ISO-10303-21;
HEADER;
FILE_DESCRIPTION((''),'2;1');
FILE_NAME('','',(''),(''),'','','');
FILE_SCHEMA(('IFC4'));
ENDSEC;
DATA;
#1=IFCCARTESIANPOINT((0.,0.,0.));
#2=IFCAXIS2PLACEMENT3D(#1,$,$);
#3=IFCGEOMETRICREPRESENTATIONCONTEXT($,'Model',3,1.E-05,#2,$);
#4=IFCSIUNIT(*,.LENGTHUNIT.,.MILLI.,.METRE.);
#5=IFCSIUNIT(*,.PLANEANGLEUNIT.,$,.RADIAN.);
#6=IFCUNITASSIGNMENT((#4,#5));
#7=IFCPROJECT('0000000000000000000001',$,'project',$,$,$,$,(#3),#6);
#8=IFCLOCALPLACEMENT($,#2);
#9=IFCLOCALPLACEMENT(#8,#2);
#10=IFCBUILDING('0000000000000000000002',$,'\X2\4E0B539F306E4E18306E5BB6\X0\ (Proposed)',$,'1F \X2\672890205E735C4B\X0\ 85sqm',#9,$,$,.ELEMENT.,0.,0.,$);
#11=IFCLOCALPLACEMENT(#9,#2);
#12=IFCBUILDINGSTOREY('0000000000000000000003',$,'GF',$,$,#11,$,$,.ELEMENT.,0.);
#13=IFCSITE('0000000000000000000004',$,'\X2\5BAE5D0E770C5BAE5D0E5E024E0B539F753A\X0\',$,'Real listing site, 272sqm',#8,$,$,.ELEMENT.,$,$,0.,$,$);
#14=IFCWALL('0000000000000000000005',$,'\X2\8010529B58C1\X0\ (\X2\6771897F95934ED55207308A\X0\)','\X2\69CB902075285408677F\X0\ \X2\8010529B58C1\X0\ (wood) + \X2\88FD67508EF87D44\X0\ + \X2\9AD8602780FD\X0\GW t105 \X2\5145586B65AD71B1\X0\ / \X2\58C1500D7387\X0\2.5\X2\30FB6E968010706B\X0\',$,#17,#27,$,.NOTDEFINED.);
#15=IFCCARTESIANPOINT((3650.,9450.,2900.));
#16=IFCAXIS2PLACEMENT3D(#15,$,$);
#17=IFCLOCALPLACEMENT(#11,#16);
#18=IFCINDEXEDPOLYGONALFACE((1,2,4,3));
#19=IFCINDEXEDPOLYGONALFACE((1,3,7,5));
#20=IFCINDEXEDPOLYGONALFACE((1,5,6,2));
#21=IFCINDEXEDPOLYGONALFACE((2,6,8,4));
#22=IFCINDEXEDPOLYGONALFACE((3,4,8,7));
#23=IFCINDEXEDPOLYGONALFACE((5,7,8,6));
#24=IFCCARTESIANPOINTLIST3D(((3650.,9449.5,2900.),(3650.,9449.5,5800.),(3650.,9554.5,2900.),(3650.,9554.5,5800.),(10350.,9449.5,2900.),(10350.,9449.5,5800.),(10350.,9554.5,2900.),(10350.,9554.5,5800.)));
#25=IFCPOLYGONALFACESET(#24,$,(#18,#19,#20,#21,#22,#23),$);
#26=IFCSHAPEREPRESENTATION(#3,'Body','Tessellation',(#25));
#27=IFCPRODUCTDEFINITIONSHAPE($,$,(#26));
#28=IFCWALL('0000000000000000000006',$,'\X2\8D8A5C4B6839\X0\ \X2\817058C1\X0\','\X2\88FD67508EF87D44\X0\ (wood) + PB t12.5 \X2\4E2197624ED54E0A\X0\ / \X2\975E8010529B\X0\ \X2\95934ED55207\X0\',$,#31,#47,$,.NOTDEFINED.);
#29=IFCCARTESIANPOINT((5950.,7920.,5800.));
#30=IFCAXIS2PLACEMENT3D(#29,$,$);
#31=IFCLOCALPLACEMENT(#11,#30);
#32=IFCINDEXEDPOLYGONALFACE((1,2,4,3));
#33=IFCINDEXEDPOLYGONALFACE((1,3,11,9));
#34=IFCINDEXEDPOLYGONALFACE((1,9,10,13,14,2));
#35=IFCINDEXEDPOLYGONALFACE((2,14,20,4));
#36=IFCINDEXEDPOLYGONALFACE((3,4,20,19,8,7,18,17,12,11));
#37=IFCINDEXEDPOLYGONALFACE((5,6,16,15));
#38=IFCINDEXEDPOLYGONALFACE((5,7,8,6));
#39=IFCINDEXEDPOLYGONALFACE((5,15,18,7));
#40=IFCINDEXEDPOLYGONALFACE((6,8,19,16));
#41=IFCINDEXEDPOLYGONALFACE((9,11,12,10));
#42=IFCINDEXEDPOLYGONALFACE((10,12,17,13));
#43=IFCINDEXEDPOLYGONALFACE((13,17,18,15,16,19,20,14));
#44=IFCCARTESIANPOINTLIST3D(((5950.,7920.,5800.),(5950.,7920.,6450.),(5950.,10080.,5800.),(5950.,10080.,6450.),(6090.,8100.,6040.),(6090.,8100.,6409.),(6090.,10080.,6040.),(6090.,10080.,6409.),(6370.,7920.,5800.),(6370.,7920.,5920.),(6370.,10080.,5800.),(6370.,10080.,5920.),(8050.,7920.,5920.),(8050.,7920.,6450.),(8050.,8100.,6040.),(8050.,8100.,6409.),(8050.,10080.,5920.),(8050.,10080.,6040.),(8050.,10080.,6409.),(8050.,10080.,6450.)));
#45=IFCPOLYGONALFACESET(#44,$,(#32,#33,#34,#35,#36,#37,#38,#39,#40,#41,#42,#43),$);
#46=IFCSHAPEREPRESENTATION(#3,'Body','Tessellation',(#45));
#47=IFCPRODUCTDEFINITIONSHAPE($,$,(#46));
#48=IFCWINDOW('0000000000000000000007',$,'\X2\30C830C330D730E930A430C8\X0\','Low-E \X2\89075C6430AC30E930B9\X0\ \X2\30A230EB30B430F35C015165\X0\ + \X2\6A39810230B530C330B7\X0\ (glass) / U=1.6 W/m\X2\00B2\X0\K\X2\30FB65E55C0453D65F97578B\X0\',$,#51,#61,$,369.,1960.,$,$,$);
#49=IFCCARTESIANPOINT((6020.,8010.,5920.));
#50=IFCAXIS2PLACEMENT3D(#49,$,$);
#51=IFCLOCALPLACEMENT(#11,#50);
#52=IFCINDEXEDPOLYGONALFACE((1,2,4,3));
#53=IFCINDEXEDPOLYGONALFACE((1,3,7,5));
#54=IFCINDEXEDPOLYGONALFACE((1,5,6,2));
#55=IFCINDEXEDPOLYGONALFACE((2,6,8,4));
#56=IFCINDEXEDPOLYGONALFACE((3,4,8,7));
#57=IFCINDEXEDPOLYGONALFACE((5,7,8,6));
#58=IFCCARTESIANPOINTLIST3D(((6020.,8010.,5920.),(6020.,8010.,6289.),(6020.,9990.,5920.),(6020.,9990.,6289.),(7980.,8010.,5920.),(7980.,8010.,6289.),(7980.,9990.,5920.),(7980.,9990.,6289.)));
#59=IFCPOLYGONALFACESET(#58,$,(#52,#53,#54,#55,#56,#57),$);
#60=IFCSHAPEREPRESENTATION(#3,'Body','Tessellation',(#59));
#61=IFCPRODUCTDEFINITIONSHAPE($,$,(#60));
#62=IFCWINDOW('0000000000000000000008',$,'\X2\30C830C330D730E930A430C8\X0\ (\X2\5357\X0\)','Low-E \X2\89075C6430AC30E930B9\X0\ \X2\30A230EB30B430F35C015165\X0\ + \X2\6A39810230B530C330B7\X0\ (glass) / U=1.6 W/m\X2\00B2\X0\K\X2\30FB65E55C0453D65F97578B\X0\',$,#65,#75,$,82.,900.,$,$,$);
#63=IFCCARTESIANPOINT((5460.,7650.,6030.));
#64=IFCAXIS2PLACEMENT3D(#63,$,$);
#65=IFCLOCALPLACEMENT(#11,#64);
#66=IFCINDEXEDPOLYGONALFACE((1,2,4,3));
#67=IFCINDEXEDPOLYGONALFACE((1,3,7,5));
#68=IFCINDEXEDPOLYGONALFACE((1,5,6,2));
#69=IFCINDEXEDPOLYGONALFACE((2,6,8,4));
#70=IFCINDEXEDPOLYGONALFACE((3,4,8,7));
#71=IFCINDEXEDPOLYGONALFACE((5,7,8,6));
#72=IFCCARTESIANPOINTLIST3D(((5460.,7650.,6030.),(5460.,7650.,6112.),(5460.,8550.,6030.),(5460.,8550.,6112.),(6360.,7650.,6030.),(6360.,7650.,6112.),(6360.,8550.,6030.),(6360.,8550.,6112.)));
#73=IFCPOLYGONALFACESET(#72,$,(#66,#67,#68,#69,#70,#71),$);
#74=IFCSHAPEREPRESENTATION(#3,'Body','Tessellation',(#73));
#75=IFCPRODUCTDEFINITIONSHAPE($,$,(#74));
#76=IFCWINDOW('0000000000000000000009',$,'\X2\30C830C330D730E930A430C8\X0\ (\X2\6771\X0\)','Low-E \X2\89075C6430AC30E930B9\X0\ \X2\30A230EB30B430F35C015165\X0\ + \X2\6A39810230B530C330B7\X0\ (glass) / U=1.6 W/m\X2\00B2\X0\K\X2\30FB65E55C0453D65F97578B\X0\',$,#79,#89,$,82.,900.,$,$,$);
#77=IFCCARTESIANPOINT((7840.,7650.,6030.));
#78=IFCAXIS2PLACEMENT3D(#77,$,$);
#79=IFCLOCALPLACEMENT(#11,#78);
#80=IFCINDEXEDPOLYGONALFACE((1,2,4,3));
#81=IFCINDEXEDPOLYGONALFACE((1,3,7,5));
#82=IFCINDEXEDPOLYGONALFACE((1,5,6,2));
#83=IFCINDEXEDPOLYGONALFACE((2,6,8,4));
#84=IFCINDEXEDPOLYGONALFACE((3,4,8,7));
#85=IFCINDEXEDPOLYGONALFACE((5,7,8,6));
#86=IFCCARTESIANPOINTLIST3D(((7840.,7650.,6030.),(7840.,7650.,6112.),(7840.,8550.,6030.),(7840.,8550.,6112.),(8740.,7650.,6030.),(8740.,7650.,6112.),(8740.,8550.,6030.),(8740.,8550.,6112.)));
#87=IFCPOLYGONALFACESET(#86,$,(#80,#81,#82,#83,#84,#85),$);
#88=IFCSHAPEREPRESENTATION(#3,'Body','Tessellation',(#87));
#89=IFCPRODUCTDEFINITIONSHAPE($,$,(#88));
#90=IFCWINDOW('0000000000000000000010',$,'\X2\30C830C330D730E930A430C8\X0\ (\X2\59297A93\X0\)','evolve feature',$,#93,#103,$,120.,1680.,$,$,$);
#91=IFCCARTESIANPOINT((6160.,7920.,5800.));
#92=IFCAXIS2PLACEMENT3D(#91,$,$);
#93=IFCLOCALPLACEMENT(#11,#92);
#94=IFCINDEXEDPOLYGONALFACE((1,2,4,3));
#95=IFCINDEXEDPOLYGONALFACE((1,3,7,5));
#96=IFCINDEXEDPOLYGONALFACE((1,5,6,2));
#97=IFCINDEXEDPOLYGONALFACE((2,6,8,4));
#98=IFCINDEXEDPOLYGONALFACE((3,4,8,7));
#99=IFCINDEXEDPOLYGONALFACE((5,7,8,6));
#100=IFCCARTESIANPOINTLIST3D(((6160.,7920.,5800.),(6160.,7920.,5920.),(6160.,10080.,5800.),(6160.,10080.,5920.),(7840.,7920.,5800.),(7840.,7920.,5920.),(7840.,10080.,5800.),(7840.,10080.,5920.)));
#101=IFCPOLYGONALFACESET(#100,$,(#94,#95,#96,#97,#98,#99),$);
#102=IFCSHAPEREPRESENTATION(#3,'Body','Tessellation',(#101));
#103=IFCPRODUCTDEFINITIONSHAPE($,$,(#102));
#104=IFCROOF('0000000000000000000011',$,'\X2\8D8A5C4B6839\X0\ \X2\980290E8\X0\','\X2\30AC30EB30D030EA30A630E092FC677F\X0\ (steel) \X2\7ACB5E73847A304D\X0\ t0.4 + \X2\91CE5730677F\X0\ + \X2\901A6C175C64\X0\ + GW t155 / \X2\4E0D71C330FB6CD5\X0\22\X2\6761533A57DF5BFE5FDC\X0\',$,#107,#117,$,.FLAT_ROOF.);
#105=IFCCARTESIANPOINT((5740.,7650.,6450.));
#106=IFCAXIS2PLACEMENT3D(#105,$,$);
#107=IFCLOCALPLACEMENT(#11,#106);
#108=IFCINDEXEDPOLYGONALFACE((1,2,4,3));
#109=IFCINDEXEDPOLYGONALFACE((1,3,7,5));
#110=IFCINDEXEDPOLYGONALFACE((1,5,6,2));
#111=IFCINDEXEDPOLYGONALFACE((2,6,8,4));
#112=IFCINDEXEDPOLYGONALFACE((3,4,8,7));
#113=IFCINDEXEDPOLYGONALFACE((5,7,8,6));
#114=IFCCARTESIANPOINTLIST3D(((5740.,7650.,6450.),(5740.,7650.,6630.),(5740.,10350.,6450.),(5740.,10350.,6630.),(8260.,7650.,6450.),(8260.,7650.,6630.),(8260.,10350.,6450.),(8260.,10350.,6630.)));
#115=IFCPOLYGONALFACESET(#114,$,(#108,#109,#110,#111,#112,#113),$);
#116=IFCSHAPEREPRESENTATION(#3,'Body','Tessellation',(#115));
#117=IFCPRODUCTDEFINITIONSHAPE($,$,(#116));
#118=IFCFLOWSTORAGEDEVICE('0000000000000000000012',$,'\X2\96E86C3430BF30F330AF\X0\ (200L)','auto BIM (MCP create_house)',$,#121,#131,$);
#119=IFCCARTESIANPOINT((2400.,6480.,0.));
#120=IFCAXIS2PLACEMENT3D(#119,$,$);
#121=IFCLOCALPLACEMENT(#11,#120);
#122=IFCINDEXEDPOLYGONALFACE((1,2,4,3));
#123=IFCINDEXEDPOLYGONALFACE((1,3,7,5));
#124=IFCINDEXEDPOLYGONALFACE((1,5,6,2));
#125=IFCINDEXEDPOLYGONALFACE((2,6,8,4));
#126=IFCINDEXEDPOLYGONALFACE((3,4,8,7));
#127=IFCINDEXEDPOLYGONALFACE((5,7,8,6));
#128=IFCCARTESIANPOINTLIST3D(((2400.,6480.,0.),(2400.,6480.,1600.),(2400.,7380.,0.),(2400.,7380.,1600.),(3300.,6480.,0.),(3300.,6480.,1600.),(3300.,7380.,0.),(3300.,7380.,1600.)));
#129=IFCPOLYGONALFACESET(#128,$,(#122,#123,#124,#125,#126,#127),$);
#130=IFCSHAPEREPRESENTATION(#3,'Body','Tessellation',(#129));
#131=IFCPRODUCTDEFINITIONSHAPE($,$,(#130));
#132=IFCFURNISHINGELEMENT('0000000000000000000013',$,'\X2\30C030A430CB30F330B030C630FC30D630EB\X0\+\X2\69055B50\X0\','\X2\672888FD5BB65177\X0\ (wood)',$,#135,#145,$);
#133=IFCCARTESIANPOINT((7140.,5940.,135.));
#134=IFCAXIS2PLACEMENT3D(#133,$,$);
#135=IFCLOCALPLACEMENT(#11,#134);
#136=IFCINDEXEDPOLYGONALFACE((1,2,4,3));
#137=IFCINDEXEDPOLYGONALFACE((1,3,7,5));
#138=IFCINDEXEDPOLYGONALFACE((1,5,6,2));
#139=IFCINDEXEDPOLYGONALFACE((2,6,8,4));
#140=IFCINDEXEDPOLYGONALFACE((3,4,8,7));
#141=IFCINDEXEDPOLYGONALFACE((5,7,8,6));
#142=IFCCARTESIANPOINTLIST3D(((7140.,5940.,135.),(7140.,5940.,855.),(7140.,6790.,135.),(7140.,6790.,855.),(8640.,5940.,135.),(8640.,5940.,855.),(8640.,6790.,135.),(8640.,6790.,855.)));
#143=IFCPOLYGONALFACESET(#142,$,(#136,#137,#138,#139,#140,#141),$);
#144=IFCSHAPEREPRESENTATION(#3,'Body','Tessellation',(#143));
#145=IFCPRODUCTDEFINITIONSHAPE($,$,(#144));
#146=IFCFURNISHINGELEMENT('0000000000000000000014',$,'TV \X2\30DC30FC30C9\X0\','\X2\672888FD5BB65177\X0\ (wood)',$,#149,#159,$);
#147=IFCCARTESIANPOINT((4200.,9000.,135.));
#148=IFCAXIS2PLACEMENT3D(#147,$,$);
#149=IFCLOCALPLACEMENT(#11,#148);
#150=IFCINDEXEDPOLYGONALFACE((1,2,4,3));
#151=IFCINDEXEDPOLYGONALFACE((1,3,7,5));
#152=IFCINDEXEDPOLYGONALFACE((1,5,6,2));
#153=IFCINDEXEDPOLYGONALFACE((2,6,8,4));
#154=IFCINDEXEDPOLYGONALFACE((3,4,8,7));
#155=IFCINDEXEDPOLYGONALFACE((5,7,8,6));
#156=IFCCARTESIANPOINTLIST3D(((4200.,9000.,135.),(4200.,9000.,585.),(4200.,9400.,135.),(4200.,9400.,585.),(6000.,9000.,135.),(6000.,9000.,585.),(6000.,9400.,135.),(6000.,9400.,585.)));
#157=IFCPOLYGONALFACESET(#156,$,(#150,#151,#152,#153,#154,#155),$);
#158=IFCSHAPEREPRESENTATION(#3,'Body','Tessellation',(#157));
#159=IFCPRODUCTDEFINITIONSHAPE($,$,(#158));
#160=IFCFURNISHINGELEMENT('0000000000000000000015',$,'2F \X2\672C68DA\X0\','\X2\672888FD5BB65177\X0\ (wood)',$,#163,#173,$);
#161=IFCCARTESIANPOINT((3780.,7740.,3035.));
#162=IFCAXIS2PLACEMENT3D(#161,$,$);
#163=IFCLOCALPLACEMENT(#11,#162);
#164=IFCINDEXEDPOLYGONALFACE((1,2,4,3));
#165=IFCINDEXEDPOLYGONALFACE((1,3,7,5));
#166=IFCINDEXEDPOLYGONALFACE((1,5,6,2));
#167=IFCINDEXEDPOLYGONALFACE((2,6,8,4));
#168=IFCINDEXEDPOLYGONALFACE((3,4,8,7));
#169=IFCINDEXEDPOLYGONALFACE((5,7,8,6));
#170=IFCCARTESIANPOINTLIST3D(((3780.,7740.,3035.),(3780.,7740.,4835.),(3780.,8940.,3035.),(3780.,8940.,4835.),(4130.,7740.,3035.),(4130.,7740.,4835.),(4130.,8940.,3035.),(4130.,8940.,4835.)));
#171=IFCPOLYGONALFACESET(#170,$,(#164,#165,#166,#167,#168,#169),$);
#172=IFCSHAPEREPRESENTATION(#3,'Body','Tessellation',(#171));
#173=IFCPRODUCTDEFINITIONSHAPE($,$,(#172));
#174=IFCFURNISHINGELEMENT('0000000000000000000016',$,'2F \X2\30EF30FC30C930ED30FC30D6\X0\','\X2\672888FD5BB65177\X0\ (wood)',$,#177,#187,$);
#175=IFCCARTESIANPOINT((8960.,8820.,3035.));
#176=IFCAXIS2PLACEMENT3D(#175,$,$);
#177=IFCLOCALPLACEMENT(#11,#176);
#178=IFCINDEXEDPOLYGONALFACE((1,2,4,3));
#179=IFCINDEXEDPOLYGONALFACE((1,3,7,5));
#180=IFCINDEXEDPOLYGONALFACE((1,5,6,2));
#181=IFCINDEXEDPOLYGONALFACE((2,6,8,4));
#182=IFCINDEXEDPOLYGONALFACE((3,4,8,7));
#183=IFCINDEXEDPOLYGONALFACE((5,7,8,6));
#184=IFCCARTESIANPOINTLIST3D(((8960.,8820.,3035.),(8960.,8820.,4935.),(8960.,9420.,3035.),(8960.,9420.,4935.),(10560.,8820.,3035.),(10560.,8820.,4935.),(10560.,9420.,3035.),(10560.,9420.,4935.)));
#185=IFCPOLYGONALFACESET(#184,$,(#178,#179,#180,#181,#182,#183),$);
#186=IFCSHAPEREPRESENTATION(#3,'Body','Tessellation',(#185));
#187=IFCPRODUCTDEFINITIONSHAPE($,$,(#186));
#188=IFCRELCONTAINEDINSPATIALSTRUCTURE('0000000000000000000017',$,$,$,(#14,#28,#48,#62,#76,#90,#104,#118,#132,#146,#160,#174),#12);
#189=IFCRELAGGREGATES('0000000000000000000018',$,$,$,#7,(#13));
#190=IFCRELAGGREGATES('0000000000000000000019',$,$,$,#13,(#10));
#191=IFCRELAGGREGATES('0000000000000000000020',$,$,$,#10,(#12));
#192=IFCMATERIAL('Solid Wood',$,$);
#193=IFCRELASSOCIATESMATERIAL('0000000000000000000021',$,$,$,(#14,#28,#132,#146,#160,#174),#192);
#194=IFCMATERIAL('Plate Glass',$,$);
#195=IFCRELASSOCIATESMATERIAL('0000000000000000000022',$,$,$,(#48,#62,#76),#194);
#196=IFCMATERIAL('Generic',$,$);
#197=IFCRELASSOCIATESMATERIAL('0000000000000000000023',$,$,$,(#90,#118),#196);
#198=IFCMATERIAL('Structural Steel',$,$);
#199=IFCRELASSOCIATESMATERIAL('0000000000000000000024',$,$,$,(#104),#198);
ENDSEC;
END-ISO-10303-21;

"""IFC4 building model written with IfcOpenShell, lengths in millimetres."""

from ifc_helpers import new_model, si_unit, frame, frame_2d, origin, place, context, project, spatial, rectangle, extrude, material, element, fill, save


model = new_model("IFC4")

# Units and contexts
model_context = context("Model", 3, precision=1e-05, world=origin())
ifc_project = project(units=[si_unit("LENGTHUNIT", "METRE", prefix="MILLI"), si_unit("PLANEANGLEUNIT", "RADIAN")], contexts=[model_context])

# Site, building, storey
site_placement = place(None, origin())
site = spatial("IfcSite", under=ifc_project, at=site_placement, Name="宮崎県宮崎市下原町", ObjectType="Real listing site, 272sqm", CompositionType="ELEMENT", RefElevation=0.0)
building_placement = place(site_placement, origin())
building = spatial("IfcBuilding", under=site, at=building_placement, Name="下原の丘の家 (Proposed)", ObjectType="1F 木造平屋 85sqm", CompositionType="ELEMENT", ElevationOfRefHeight=0.0, ElevationOfTerrain=0.0)
storey_placement = place(building_placement, origin())
storey = spatial("IfcBuildingStorey", under=building, at=storey_placement, Name="GF", CompositionType="ELEMENT", Elevation=0.0)

# Wall
ifc_material_1 = material(Name="Solid Wood")
wall_1_placement = place(storey_placement, frame((3650.0, 9450.0, 2900.0)))
element("IfcWall", 1, at=wall_1_placement, inside=storey, material=ifc_material_1, Name="耐力壁 (東西間仕切り)", Description="構造用合板 耐力壁 (wood) + 製材軸組 + 高性能GW t105 充填断熱 / 壁倍率2.5・準耐火", PredefinedType="NOTDEFINED", context=model_context, shape_type="SweptSolid", body=[
    extrude(rectangle(XDim=6700.0, YDim=105.0, at=frame_2d((3350.0, 52.0))), frame((3650.0, 9450.0, 2900.0)), (0.0, 0.0, 1.0), 2900.0),
])

# Wall, openings, windows
wall_2_placement = place(storey_placement, frame((5950.0, 7920.0, 5800.0)))
wall_2 = element("IfcWall", 2, at=wall_2_placement, inside=storey, material=ifc_material_1, Name="越屋根 腰壁", Description="製材軸組 (wood) + PB t12.5 両面仕上 / 非耐力 間仕切", PredefinedType="NOTDEFINED", context=model_context, shape_type="SweptSolid", body=[
    extrude(rectangle(XDim=2100.0, YDim=2160.0, at=frame_2d((1050.0, 1080.0))), frame((5950.0, 7920.0, 5800.0)), (0.0, 0.0, 1.0), 650.0),
])
opening_1_placement = place(storey_placement, frame((6020.0, 8010.0, 5920.0)))
opening_1 = element("IfcOpeningElement", 3, at=opening_1_placement, cuts=wall_2, PredefinedType="NOTDEFINED", context=model_context, shape_type="SweptSolid", body=[
    extrude(rectangle(XDim=1960.0, YDim=1980.0, at=frame_2d((980.0, 990.0))), frame((6020.0, 8010.0, 5920.0)), (0.0, 0.0, 1.0), 369.0),
])
opening_2_placement = place(storey_placement, frame((5460.0, 7650.0, 6030.0)))
opening_2 = element("IfcOpeningElement", 4, at=opening_2_placement, cuts=wall_2, PredefinedType="NOTDEFINED", context=model_context, shape_type="SweptSolid", body=[
    extrude(rectangle(XDim=900.0, YDim=900.0, at=frame_2d((450.0, 450.0))), frame((5460.0, 7650.0, 6030.0)), (0.0, 0.0, 1.0), 82.0),
])
opening_3_placement = place(storey_placement, frame((7840.0, 7650.0, 6030.0)))
opening_3 = element("IfcOpeningElement", 5, at=opening_3_placement, cuts=wall_2, PredefinedType="NOTDEFINED", context=model_context, shape_type="SweptSolid", body=[
    extrude(rectangle(XDim=900.0, YDim=900.0, at=frame_2d((450.0, 450.0))), frame((7840.0, 7650.0, 6030.0)), (0.0, 0.0, 1.0), 82.0),
])
opening_4_placement = place(storey_placement, frame((6160.0, 7920.0, 5800.0)))
opening_4 = element("IfcOpeningElement", 6, at=opening_4_placement, cuts=wall_2, PredefinedType="NOTDEFINED", context=model_context, shape_type="SweptSolid", body=[
    extrude(rectangle(XDim=1680.0, YDim=2160.0, at=frame_2d((840.0, 1080.0))), frame((6160.0, 7920.0, 5800.0)), (0.0, 0.0, 1.0), 120.0),
])
ifc_material_2 = material(Name="Plate Glass")
window_1_placement = place(storey_placement, frame((6020.0, 8010.0, 5920.0)))
window_1 = element("IfcWindow", 7, at=window_1_placement, inside=storey, material=ifc_material_2, Name="トップライト", Description="Low-E 複層ガラス アルゴン封入 + 樹脂サッシ (glass) / U=1.6 W/m²K・日射取得型", OverallHeight=369.0, OverallWidth=1960.0, context=model_context, shape_type="SweptSolid", body=[
    extrude(rectangle(XDim=1960.0, YDim=1980.0, at=frame_2d((980.0, 990.0))), frame((6020.0, 8010.0, 5920.0)), (0.0, 0.0, 1.0), 369.0),
])
fill(opening_1, window_1)
window_2_placement = place(storey_placement, frame((5460.0, 7650.0, 6030.0)))
window_2 = element("IfcWindow", 8, at=window_2_placement, inside=storey, material=ifc_material_2, Name="トップライト (南)", Description="Low-E 複層ガラス アルゴン封入 + 樹脂サッシ (glass) / U=1.6 W/m²K・日射取得型", OverallHeight=82.0, OverallWidth=900.0, context=model_context, shape_type="SweptSolid", body=[
    extrude(rectangle(XDim=900.0, YDim=900.0, at=frame_2d((450.0, 450.0))), frame((5460.0, 7650.0, 6030.0)), (0.0, 0.0, 1.0), 82.0),
])
fill(opening_2, window_2)
window_3_placement = place(storey_placement, frame((7840.0, 7650.0, 6030.0)))
window_3 = element("IfcWindow", 9, at=window_3_placement, inside=storey, material=ifc_material_2, Name="トップライト (東)", Description="Low-E 複層ガラス アルゴン封入 + 樹脂サッシ (glass) / U=1.6 W/m²K・日射取得型", OverallHeight=82.0, OverallWidth=900.0, context=model_context, shape_type="SweptSolid", body=[
    extrude(rectangle(XDim=900.0, YDim=900.0, at=frame_2d((450.0, 450.0))), frame((7840.0, 7650.0, 6030.0)), (0.0, 0.0, 1.0), 82.0),
])
fill(opening_3, window_3)
ifc_material_3 = material(Name="Generic")
window_4_placement = place(storey_placement, frame((6160.0, 7920.0, 5800.0)))
window_4 = element("IfcWindow", 10, at=window_4_placement, inside=storey, material=ifc_material_3, Name="トップライト (天窓)", Description="evolve feature", OverallHeight=120.0, OverallWidth=1680.0, context=model_context, shape_type="SweptSolid", body=[
    extrude(rectangle(XDim=1680.0, YDim=2160.0, at=frame_2d((840.0, 1080.0))), frame((6160.0, 7920.0, 5800.0)), (0.0, 0.0, 1.0), 120.0),
])
fill(opening_4, window_4)

# Roof
ifc_material_4 = material(Name="Structural Steel")
roof_placement = place(storey_placement, frame((5740.0, 7650.0, 6450.0)))
element("IfcRoof", 11, at=roof_placement, inside=storey, material=ifc_material_4, Name="越屋根 頂部", Description="ガルバリウム鋼板 (steel) 立平葺き t0.4 + 野地板 + 通気層 + GW t155 / 不燃・法22条区域対応", PredefinedType="FLAT_ROOF", context=model_context, shape_type="SweptSolid", body=[
    extrude(rectangle(XDim=2520.0, YDim=2700.0, at=frame_2d((1260.0, 1350.0))), frame((5740.0, 7650.0, 6450.0)), (0.0, 0.0, 1.0), 180.0),
])

# Flow storage device
flow_storage_device_placement = place(storey_placement, frame((2400.0, 6480.0, 0.0)))
element("IfcFlowStorageDevice", 12, at=flow_storage_device_placement, inside=storey, material=ifc_material_3, Name="雨水タンク (200L)", Description="auto BIM (MCP create_house)", context=model_context, shape_type="SweptSolid", body=[
    extrude(rectangle(XDim=900.0, YDim=900.0, at=frame_2d((450.0, 450.0))), frame((2400.0, 6480.0, 0.0)), (0.0, 0.0, 1.0), 1600.0),
])

# Furnishing elements
furnishing_1_placement = place(storey_placement, frame((7140.0, 5940.0, 135.0)))
element("IfcFurnishingElement", 13, at=furnishing_1_placement, inside=storey, material=ifc_material_1, Name="ダイニングテーブル+椅子", Description="木製家具 (wood)", context=model_context, shape_type="SweptSolid", body=[
    extrude(rectangle(XDim=1500.0, YDim=850.0, at=frame_2d((750.0, 425.0))), frame((7140.0, 5940.0, 135.0)), (0.0, 0.0, 1.0), 720.0),
])
furnishing_2_placement = place(storey_placement, frame((4200.0, 9000.0, 135.0)))
element("IfcFurnishingElement", 14, at=furnishing_2_placement, inside=storey, material=ifc_material_1, Name="TV ボード", Description="木製家具 (wood)", context=model_context, shape_type="SweptSolid", body=[
    extrude(rectangle(XDim=1800.0, YDim=400.0, at=frame_2d((900.0, 200.0))), frame((4200.0, 9000.0, 135.0)), (0.0, 0.0, 1.0), 450.0),
])
furnishing_3_placement = place(storey_placement, frame((3780.0, 7740.0, 3035.0)))
element("IfcFurnishingElement", 15, at=furnishing_3_placement, inside=storey, material=ifc_material_1, Name="2F 本棚", Description="木製家具 (wood)", context=model_context, shape_type="SweptSolid", body=[
    extrude(rectangle(XDim=350.0, YDim=1200.0, at=frame_2d((175.0, 600.0))), frame((3780.0, 7740.0, 3035.0)), (0.0, 0.0, 1.0), 1800.0),
])
furnishing_4_placement = place(storey_placement, frame((8960.0, 8820.0, 3035.0)))
element("IfcFurnishingElement", 16, at=furnishing_4_placement, inside=storey, material=ifc_material_1, Name="2F ワードローブ", Description="木製家具 (wood)", context=model_context, shape_type="SweptSolid", body=[
    extrude(rectangle(XDim=1600.0, YDim=600.0, at=frame_2d((800.0, 300.0))), frame((8960.0, 8820.0, 3035.0)), (0.0, 0.0, 1.0), 1900.0),
])

save(model, "model.ifc")
